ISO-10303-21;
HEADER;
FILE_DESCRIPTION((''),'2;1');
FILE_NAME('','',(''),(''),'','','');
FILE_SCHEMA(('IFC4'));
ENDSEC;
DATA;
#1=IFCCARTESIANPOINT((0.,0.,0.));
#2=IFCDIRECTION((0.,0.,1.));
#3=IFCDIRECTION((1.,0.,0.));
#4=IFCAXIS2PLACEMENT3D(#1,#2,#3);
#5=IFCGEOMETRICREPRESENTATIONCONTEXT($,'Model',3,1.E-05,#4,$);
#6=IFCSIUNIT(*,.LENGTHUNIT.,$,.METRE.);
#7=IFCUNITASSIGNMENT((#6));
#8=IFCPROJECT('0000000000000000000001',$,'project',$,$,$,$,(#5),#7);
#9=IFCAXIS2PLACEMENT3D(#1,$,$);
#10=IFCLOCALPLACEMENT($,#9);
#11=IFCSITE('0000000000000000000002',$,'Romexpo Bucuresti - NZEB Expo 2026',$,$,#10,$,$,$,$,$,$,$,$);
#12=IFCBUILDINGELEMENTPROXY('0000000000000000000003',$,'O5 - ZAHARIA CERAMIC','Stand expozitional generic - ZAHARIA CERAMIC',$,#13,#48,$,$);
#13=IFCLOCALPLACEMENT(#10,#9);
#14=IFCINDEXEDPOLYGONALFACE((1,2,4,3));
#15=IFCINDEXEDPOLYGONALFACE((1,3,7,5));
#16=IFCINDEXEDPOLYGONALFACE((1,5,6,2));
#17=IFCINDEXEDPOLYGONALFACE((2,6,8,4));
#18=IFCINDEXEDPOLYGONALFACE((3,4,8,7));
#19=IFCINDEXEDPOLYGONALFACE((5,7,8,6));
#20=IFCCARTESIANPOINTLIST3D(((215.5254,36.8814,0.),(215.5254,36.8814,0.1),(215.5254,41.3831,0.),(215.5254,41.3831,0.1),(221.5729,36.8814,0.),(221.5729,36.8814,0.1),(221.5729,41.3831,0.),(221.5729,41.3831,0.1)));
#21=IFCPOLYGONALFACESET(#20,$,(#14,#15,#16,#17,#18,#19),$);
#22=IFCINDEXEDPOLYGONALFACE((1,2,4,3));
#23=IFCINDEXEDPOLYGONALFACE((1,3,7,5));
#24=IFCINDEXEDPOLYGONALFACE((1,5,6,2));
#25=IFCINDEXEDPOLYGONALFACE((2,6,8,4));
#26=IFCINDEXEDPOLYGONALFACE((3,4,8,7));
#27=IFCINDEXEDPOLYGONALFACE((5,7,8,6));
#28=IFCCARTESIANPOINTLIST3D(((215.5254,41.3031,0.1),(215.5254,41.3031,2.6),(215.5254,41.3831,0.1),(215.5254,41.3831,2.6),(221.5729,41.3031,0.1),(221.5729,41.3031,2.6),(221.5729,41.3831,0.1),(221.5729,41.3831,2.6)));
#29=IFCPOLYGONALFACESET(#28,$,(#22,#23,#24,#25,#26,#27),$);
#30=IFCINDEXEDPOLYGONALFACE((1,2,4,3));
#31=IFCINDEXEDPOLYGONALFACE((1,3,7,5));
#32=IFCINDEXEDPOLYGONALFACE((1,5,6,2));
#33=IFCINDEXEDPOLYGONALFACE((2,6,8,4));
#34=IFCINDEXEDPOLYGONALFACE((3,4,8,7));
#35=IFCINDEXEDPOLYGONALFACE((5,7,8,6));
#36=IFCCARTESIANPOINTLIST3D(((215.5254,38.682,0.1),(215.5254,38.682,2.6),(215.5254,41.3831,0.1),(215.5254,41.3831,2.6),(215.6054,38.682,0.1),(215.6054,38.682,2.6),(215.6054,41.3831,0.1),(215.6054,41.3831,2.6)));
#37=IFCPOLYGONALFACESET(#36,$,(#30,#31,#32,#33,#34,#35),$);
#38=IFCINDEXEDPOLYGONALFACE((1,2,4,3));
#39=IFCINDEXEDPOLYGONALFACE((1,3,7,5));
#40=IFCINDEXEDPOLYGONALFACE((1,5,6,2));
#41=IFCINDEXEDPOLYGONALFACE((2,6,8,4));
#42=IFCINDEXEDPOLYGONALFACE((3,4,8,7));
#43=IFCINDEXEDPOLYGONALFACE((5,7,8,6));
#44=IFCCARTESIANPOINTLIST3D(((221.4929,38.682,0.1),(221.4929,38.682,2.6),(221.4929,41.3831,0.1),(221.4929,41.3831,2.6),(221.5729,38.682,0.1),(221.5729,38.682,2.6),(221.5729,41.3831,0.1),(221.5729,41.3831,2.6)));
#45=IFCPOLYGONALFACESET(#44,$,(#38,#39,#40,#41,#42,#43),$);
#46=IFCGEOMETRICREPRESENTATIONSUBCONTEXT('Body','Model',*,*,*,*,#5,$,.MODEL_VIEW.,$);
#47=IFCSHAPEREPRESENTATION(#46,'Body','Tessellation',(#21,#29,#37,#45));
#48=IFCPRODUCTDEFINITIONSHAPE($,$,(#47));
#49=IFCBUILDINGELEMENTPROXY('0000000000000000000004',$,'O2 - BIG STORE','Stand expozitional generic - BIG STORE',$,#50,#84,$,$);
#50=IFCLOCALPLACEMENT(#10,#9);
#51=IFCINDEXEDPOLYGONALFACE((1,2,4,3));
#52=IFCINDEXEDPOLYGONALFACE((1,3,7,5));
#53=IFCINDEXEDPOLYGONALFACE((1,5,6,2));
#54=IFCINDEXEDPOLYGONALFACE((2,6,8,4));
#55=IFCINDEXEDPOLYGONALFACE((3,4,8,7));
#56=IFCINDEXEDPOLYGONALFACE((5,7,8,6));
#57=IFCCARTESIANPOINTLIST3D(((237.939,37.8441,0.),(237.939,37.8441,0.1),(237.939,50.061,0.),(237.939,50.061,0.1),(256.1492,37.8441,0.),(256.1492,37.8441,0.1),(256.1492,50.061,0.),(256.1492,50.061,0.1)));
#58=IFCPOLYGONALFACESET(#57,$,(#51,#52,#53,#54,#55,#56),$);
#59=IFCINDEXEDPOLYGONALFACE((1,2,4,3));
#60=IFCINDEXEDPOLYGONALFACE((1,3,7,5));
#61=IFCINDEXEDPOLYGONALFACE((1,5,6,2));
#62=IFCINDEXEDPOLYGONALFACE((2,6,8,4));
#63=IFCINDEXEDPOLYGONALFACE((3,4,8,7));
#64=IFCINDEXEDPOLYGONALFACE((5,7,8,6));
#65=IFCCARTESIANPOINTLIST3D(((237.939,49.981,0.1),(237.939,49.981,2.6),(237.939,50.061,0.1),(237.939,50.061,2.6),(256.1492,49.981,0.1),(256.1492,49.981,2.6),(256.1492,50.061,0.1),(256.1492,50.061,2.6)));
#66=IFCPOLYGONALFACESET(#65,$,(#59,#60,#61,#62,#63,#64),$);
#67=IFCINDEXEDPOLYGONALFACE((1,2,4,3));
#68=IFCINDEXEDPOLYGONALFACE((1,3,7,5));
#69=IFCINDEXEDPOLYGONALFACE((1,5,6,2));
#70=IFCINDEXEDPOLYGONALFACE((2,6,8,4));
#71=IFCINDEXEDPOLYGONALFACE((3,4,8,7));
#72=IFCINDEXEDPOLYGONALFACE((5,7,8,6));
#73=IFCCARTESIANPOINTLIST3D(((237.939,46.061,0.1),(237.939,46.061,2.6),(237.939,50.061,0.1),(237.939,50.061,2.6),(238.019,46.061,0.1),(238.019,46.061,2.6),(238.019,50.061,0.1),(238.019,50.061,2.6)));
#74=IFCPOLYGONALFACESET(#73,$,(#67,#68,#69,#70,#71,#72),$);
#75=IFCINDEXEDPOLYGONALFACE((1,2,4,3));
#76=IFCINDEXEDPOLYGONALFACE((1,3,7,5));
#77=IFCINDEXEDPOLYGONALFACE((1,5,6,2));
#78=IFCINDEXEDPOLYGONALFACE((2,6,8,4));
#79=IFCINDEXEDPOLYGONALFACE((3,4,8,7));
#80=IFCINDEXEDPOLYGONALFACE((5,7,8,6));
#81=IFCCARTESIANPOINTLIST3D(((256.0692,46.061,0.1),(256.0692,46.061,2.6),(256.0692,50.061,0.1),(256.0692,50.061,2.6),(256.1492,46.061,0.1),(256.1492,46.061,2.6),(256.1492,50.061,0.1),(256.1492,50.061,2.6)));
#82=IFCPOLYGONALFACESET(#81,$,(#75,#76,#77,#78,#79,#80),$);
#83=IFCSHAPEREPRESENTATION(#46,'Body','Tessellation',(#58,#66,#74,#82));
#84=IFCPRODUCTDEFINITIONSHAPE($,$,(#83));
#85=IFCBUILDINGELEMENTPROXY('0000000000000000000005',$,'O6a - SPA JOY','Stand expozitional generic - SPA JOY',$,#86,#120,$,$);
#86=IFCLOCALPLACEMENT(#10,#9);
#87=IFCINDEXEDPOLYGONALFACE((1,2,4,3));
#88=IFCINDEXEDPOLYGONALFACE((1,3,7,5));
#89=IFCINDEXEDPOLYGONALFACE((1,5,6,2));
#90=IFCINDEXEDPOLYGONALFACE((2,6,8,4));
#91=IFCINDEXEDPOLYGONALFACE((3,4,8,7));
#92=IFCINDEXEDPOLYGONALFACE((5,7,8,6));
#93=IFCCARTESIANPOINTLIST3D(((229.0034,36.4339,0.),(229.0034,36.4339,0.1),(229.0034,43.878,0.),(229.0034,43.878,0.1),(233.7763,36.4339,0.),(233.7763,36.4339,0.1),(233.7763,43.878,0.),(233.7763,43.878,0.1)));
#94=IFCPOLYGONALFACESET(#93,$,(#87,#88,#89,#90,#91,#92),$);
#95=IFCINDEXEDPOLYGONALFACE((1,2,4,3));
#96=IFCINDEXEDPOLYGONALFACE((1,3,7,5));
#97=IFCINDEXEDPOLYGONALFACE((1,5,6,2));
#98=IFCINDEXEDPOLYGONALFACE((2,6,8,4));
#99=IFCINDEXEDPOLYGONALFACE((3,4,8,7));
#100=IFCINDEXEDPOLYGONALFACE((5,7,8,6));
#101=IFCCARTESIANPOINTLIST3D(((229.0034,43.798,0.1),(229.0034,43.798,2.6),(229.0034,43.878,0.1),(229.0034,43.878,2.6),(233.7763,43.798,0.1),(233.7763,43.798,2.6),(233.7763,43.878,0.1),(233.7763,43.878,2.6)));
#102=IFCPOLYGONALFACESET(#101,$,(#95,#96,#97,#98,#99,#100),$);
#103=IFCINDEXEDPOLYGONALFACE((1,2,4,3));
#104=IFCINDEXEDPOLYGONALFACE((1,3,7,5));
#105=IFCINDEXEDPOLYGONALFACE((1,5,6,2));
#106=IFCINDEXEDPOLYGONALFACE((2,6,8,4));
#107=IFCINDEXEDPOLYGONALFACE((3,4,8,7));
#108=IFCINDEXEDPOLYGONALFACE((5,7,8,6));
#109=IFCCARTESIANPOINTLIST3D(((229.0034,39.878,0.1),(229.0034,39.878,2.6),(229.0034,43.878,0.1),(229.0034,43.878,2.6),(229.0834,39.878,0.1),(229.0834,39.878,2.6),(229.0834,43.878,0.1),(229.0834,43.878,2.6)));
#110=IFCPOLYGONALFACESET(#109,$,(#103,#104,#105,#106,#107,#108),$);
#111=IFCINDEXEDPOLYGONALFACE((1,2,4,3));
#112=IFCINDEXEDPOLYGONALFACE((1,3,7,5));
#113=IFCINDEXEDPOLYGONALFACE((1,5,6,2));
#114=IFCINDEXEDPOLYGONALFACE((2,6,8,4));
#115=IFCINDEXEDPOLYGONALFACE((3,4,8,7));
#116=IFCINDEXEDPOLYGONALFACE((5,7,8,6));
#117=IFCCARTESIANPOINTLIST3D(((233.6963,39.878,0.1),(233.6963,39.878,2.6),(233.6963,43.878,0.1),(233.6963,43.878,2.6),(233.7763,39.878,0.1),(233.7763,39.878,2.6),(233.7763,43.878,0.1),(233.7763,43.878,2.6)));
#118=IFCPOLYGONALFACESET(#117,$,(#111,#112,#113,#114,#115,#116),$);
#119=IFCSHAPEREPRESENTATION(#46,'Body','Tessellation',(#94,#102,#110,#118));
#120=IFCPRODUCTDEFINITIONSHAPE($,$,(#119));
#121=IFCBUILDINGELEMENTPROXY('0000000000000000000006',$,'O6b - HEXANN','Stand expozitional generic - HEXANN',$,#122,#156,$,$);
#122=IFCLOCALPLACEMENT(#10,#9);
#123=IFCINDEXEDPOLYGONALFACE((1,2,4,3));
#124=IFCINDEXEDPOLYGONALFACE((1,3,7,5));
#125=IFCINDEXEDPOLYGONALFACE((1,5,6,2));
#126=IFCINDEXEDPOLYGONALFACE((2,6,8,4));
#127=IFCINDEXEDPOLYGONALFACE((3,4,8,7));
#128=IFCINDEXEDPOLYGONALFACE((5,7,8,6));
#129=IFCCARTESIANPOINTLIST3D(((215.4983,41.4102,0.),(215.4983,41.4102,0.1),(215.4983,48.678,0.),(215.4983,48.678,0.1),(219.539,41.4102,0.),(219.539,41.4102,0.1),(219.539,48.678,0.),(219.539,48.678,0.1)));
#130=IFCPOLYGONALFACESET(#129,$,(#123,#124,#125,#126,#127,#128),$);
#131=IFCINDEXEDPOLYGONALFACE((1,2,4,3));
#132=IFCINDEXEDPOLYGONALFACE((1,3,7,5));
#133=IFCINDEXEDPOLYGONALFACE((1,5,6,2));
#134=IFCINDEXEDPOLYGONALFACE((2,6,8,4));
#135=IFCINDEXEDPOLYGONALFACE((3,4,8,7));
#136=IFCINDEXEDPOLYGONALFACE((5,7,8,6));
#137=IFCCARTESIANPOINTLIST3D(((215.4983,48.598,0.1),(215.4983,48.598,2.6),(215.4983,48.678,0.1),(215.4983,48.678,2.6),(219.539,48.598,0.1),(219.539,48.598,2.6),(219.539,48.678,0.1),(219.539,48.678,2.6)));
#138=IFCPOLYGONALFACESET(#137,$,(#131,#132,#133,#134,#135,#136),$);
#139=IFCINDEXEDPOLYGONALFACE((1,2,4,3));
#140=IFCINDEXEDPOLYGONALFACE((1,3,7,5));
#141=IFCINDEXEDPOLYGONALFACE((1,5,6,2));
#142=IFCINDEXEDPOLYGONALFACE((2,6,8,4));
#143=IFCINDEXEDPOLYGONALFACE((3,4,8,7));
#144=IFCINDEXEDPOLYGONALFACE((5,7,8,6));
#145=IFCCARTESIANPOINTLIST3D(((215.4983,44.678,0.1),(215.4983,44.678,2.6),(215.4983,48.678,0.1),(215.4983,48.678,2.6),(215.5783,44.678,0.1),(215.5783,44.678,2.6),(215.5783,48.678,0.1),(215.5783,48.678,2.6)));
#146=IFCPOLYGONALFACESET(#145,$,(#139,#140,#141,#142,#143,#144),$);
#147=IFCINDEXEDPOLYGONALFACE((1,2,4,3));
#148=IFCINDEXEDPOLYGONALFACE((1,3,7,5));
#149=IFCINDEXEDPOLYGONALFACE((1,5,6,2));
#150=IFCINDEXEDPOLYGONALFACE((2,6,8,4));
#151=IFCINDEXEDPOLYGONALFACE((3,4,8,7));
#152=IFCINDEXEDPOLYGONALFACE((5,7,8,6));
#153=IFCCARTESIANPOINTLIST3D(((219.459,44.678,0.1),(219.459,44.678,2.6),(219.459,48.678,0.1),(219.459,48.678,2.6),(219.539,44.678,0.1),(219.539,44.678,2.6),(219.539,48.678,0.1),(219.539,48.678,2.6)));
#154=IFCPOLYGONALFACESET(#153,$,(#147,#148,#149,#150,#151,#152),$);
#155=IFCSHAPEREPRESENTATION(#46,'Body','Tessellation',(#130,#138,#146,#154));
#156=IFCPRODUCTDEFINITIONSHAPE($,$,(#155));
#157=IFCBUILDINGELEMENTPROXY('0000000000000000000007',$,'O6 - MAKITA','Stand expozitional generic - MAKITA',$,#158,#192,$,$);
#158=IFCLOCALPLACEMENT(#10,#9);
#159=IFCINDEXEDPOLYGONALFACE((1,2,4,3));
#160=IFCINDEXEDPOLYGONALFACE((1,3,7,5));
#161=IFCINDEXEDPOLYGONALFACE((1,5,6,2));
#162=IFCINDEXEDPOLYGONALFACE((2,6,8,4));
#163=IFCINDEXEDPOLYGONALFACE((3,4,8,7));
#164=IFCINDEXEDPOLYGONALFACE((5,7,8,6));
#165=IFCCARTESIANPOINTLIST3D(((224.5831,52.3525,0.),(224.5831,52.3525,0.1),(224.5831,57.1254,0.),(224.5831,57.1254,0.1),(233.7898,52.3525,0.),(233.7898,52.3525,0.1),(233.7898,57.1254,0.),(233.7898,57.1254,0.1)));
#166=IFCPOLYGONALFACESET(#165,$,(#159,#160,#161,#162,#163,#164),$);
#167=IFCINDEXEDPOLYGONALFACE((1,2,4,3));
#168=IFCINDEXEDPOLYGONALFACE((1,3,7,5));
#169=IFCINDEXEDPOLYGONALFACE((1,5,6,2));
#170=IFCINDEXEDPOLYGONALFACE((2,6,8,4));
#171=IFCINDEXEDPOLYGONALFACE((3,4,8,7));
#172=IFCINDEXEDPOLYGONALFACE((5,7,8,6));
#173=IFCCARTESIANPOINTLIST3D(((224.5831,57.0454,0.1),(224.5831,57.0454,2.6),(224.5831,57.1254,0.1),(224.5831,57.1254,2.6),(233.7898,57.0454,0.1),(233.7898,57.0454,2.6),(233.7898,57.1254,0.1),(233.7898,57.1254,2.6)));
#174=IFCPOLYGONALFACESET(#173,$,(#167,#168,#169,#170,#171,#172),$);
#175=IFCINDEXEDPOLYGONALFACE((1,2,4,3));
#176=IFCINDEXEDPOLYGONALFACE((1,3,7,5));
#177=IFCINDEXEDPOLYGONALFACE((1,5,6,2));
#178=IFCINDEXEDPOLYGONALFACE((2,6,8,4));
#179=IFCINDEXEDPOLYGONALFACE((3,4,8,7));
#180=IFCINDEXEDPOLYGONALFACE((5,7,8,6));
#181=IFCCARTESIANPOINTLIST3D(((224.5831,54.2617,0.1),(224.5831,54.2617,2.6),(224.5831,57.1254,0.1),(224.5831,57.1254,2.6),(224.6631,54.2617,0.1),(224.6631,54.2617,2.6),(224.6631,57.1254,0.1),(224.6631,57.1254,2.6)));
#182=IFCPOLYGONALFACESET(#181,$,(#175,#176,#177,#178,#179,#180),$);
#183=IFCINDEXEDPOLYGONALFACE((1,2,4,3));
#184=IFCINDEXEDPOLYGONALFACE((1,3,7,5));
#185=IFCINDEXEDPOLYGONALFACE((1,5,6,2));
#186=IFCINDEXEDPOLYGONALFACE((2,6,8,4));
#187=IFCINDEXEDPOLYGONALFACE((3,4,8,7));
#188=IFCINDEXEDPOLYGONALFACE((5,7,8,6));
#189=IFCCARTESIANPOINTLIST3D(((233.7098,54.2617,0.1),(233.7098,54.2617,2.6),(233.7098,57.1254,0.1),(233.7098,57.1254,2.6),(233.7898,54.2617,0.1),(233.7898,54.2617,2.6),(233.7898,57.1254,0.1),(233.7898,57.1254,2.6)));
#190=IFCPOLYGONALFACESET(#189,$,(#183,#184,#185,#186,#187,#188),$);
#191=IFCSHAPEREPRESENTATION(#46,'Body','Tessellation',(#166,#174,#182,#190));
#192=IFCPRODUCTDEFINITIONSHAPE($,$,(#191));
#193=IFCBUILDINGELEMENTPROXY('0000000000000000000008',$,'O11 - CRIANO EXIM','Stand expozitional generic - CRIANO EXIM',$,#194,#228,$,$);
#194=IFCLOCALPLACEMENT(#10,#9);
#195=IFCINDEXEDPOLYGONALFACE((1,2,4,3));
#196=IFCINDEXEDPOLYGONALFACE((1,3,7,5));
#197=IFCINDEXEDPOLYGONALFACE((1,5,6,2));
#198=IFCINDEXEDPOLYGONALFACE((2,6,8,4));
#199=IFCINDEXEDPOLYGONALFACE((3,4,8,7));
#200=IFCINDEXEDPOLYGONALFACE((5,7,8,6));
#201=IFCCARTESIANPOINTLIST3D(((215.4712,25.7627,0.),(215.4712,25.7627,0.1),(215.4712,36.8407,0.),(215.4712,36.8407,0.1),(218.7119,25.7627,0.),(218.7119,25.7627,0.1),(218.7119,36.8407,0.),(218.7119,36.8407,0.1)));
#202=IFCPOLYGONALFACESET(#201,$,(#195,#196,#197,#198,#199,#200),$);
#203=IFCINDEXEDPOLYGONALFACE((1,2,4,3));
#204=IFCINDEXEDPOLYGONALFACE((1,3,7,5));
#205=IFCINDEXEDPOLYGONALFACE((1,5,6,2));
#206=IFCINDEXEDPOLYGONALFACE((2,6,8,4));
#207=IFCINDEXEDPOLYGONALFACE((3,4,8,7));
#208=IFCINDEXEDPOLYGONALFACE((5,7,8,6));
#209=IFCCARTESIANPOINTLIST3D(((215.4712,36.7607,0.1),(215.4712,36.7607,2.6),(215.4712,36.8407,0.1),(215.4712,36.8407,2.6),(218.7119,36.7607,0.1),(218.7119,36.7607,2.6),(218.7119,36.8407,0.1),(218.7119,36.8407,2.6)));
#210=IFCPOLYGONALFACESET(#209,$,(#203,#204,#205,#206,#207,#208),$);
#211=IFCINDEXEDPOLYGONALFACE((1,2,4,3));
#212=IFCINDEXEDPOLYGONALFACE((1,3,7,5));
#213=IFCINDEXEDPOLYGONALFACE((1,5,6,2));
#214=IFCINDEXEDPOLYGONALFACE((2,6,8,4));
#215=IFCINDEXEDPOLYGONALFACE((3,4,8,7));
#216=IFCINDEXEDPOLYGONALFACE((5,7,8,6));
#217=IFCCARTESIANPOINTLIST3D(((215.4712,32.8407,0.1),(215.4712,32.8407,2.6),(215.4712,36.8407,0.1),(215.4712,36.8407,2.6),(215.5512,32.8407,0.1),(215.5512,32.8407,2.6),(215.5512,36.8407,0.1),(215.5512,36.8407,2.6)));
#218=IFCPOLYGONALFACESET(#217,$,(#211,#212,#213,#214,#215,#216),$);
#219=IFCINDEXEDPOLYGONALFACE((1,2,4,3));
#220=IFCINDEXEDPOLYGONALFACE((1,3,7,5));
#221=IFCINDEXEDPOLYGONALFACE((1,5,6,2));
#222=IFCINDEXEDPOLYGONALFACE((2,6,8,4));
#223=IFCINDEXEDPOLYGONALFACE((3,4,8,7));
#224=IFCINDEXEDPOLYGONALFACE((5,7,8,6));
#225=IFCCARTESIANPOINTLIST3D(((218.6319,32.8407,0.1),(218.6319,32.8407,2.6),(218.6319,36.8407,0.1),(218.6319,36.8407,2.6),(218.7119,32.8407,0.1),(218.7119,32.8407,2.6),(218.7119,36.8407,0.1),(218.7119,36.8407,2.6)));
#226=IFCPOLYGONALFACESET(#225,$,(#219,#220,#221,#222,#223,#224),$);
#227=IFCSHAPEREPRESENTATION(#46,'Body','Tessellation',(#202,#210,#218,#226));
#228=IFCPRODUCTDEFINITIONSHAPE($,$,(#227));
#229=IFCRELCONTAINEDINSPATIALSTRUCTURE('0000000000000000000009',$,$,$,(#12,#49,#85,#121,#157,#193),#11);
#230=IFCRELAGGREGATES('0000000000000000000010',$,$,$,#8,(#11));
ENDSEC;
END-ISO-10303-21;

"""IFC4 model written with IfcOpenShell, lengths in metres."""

from ifc_helpers import new_model, si_unit, frame, frame_2d, origin, origin_with_axes, place, context, subcontext, project, spatial, rectangle, extrude, element, save


model = new_model("IFC4")

# Units and contexts
model_context = context("Model", 3, precision=1e-05, world=origin_with_axes())
body_context = subcontext(model_context, "Body", "Model", "MODEL_VIEW")
ifc_project = project(units=[si_unit("LENGTHUNIT", "METRE")], contexts=[model_context])

# Site
site_placement = place(None, origin())
site = spatial("IfcSite", under=ifc_project, at=site_placement, Name="Romexpo Bucuresti - NZEB Expo 2026")

# Building element proxies
proxy_1_placement = place(site_placement, frame((215.5254, 36.8814, 0.0), z_axis=(0.0, 0.0, 1.0), x_axis=(1.0, 0.0, 0.0)))
element("IfcBuildingElementProxy", 1, at=proxy_1_placement, inside=site, Name="O5 - ZAHARIA CERAMIC", Description="Stand expozitional generic - ZAHARIA CERAMIC", context=body_context, shape_type="SweptSolid", body=[
    extrude(rectangle(XDim=6.0475, YDim=4.5017, at=frame_2d((3.0237, 2.2508))), origin(), (0.0, 0.0, 1.0), 0.1),
    extrude(rectangle(XDim=6.0475, YDim=0.08, at=frame_2d((3.0237, 4.4617))), frame((0.0, 0.0, 0.1)), (0.0, 0.0, 1.0), 2.5),
    extrude(rectangle(XDim=0.08, YDim=2.701, at=frame_2d((0.04, 3.1512))), frame((0.0, 0.0, 0.1)), (0.0, 0.0, 1.0), 2.5),
    extrude(rectangle(XDim=0.08, YDim=2.701, at=frame_2d((6.0075, 3.1512))), frame((0.0, 0.0, 0.1)), (0.0, 0.0, 1.0), 2.5),
])
proxy_2_placement = place(site_placement, frame((237.939, 37.8441, 0.0), z_axis=(0.0, 0.0, 1.0), x_axis=(1.0, 0.0, 0.0)))
element("IfcBuildingElementProxy", 2, at=proxy_2_placement, inside=site, Name="O2 - BIG STORE", Description="Stand expozitional generic - BIG STORE", context=body_context, shape_type="SweptSolid", body=[
    extrude(rectangle(XDim=18.2102, YDim=12.2169, at=frame_2d((9.1051, 6.1085))), origin(), (0.0, 0.0, 1.0), 0.1),
    extrude(rectangle(XDim=18.2102, YDim=0.08, at=frame_2d((9.1051, 12.1769))), frame((0.0, 0.0, 0.1)), (0.0, 0.0, 1.0), 2.5),
    extrude(rectangle(XDim=0.08, YDim=4.0, at=frame_2d((0.04, 10.2169))), frame((0.0, 0.0, 0.1)), (0.0, 0.0, 1.0), 2.5),
    extrude(rectangle(XDim=0.08, YDim=4.0, at=frame_2d((18.1702, 10.2169))), frame((0.0, 0.0, 0.1)), (0.0, 0.0, 1.0), 2.5),
])
proxy_3_placement = place(site_placement, frame((229.0034, 36.4339, 0.0), z_axis=(0.0, 0.0, 1.0), x_axis=(1.0, 0.0, 0.0)))
element("IfcBuildingElementProxy", 3, at=proxy_3_placement, inside=site, Name="O6a - SPA JOY", Description="Stand expozitional generic - SPA JOY", context=body_context, shape_type="SweptSolid", body=[
    extrude(rectangle(XDim=4.7729, YDim=7.4441, at=frame_2d((2.3864, 3.722))), origin(), (0.0, 0.0, 1.0), 0.1),
    extrude(rectangle(XDim=4.7729, YDim=0.08, at=frame_2d((2.3864, 7.4041))), frame((0.0, 0.0, 0.1)), (0.0, 0.0, 1.0), 2.5),
    extrude(rectangle(XDim=0.08, YDim=4.0, at=frame_2d((0.04, 5.4441))), frame((0.0, 0.0, 0.1)), (0.0, 0.0, 1.0), 2.5),
    extrude(rectangle(XDim=0.08, YDim=4.0, at=frame_2d((4.7329, 5.4441))), frame((0.0, 0.0, 0.1)), (0.0, 0.0, 1.0), 2.5),
])
proxy_4_placement = place(site_placement, frame((215.4983, 41.4102, 0.0), z_axis=(0.0, 0.0, 1.0), x_axis=(1.0, 0.0, 0.0)))
element("IfcBuildingElementProxy", 4, at=proxy_4_placement, inside=site, Name="O6b - HEXANN", Description="Stand expozitional generic - HEXANN", context=body_context, shape_type="SweptSolid", body=[
    extrude(rectangle(XDim=4.0407, YDim=7.2678, at=frame_2d((2.0203, 3.6339))), origin(), (0.0, 0.0, 1.0), 0.1),
    extrude(rectangle(XDim=4.0407, YDim=0.08, at=frame_2d((2.0203, 7.2278))), frame((0.0, 0.0, 0.1)), (0.0, 0.0, 1.0), 2.5),
    extrude(rectangle(XDim=0.08, YDim=4.0, at=frame_2d((0.04, 5.2678))), frame((0.0, 0.0, 0.1)), (0.0, 0.0, 1.0), 2.5),
    extrude(rectangle(XDim=0.08, YDim=4.0, at=frame_2d((4.0007, 5.2678))), frame((0.0, 0.0, 0.1)), (0.0, 0.0, 1.0), 2.5),
])
proxy_5_placement = place(site_placement, frame((224.5831, 52.3525, 0.0), z_axis=(0.0, 0.0, 1.0), x_axis=(1.0, 0.0, 0.0)))
element("IfcBuildingElementProxy", 5, at=proxy_5_placement, inside=site, Name="O6 - MAKITA", Description="Stand expozitional generic - MAKITA", context=body_context, shape_type="SweptSolid", body=[
    extrude(rectangle(XDim=9.2068, YDim=4.7729, at=frame_2d((4.6034, 2.3864))), origin(), (0.0, 0.0, 1.0), 0.1),
    extrude(rectangle(XDim=9.2068, YDim=0.08, at=frame_2d((4.6034, 4.7329))), frame((0.0, 0.0, 0.1)), (0.0, 0.0, 1.0), 2.5),
    extrude(rectangle(XDim=0.08, YDim=2.8637, at=frame_2d((0.04, 3.341))), frame((0.0, 0.0, 0.1)), (0.0, 0.0, 1.0), 2.5),
    extrude(rectangle(XDim=0.08, YDim=2.8637, at=frame_2d((9.1668, 3.341))), frame((0.0, 0.0, 0.1)), (0.0, 0.0, 1.0), 2.5),
])
proxy_6_placement = place(site_placement, frame((215.4712, 25.7627, 0.0), z_axis=(0.0, 0.0, 1.0), x_axis=(1.0, 0.0, 0.0)))
element("IfcBuildingElementProxy", 6, at=proxy_6_placement, inside=site, Name="O11 - CRIANO EXIM", Description="Stand expozitional generic - CRIANO EXIM", context=body_context, shape_type="SweptSolid", body=[
    extrude(rectangle(XDim=3.2407, YDim=11.078, at=frame_2d((1.6203, 5.539))), origin(), (0.0, 0.0, 1.0), 0.1),
    extrude(rectangle(XDim=3.2407, YDim=0.08, at=frame_2d((1.6203, 11.038))), frame((0.0, 0.0, 0.1)), (0.0, 0.0, 1.0), 2.5),
    extrude(rectangle(XDim=0.08, YDim=4.0, at=frame_2d((0.04, 9.078))), frame((0.0, 0.0, 0.1)), (0.0, 0.0, 1.0), 2.5),
    extrude(rectangle(XDim=0.08, YDim=4.0, at=frame_2d((3.2007, 9.078))), frame((0.0, 0.0, 0.1)), (0.0, 0.0, 1.0), 2.5),
])

save(model, "model.ifc")
